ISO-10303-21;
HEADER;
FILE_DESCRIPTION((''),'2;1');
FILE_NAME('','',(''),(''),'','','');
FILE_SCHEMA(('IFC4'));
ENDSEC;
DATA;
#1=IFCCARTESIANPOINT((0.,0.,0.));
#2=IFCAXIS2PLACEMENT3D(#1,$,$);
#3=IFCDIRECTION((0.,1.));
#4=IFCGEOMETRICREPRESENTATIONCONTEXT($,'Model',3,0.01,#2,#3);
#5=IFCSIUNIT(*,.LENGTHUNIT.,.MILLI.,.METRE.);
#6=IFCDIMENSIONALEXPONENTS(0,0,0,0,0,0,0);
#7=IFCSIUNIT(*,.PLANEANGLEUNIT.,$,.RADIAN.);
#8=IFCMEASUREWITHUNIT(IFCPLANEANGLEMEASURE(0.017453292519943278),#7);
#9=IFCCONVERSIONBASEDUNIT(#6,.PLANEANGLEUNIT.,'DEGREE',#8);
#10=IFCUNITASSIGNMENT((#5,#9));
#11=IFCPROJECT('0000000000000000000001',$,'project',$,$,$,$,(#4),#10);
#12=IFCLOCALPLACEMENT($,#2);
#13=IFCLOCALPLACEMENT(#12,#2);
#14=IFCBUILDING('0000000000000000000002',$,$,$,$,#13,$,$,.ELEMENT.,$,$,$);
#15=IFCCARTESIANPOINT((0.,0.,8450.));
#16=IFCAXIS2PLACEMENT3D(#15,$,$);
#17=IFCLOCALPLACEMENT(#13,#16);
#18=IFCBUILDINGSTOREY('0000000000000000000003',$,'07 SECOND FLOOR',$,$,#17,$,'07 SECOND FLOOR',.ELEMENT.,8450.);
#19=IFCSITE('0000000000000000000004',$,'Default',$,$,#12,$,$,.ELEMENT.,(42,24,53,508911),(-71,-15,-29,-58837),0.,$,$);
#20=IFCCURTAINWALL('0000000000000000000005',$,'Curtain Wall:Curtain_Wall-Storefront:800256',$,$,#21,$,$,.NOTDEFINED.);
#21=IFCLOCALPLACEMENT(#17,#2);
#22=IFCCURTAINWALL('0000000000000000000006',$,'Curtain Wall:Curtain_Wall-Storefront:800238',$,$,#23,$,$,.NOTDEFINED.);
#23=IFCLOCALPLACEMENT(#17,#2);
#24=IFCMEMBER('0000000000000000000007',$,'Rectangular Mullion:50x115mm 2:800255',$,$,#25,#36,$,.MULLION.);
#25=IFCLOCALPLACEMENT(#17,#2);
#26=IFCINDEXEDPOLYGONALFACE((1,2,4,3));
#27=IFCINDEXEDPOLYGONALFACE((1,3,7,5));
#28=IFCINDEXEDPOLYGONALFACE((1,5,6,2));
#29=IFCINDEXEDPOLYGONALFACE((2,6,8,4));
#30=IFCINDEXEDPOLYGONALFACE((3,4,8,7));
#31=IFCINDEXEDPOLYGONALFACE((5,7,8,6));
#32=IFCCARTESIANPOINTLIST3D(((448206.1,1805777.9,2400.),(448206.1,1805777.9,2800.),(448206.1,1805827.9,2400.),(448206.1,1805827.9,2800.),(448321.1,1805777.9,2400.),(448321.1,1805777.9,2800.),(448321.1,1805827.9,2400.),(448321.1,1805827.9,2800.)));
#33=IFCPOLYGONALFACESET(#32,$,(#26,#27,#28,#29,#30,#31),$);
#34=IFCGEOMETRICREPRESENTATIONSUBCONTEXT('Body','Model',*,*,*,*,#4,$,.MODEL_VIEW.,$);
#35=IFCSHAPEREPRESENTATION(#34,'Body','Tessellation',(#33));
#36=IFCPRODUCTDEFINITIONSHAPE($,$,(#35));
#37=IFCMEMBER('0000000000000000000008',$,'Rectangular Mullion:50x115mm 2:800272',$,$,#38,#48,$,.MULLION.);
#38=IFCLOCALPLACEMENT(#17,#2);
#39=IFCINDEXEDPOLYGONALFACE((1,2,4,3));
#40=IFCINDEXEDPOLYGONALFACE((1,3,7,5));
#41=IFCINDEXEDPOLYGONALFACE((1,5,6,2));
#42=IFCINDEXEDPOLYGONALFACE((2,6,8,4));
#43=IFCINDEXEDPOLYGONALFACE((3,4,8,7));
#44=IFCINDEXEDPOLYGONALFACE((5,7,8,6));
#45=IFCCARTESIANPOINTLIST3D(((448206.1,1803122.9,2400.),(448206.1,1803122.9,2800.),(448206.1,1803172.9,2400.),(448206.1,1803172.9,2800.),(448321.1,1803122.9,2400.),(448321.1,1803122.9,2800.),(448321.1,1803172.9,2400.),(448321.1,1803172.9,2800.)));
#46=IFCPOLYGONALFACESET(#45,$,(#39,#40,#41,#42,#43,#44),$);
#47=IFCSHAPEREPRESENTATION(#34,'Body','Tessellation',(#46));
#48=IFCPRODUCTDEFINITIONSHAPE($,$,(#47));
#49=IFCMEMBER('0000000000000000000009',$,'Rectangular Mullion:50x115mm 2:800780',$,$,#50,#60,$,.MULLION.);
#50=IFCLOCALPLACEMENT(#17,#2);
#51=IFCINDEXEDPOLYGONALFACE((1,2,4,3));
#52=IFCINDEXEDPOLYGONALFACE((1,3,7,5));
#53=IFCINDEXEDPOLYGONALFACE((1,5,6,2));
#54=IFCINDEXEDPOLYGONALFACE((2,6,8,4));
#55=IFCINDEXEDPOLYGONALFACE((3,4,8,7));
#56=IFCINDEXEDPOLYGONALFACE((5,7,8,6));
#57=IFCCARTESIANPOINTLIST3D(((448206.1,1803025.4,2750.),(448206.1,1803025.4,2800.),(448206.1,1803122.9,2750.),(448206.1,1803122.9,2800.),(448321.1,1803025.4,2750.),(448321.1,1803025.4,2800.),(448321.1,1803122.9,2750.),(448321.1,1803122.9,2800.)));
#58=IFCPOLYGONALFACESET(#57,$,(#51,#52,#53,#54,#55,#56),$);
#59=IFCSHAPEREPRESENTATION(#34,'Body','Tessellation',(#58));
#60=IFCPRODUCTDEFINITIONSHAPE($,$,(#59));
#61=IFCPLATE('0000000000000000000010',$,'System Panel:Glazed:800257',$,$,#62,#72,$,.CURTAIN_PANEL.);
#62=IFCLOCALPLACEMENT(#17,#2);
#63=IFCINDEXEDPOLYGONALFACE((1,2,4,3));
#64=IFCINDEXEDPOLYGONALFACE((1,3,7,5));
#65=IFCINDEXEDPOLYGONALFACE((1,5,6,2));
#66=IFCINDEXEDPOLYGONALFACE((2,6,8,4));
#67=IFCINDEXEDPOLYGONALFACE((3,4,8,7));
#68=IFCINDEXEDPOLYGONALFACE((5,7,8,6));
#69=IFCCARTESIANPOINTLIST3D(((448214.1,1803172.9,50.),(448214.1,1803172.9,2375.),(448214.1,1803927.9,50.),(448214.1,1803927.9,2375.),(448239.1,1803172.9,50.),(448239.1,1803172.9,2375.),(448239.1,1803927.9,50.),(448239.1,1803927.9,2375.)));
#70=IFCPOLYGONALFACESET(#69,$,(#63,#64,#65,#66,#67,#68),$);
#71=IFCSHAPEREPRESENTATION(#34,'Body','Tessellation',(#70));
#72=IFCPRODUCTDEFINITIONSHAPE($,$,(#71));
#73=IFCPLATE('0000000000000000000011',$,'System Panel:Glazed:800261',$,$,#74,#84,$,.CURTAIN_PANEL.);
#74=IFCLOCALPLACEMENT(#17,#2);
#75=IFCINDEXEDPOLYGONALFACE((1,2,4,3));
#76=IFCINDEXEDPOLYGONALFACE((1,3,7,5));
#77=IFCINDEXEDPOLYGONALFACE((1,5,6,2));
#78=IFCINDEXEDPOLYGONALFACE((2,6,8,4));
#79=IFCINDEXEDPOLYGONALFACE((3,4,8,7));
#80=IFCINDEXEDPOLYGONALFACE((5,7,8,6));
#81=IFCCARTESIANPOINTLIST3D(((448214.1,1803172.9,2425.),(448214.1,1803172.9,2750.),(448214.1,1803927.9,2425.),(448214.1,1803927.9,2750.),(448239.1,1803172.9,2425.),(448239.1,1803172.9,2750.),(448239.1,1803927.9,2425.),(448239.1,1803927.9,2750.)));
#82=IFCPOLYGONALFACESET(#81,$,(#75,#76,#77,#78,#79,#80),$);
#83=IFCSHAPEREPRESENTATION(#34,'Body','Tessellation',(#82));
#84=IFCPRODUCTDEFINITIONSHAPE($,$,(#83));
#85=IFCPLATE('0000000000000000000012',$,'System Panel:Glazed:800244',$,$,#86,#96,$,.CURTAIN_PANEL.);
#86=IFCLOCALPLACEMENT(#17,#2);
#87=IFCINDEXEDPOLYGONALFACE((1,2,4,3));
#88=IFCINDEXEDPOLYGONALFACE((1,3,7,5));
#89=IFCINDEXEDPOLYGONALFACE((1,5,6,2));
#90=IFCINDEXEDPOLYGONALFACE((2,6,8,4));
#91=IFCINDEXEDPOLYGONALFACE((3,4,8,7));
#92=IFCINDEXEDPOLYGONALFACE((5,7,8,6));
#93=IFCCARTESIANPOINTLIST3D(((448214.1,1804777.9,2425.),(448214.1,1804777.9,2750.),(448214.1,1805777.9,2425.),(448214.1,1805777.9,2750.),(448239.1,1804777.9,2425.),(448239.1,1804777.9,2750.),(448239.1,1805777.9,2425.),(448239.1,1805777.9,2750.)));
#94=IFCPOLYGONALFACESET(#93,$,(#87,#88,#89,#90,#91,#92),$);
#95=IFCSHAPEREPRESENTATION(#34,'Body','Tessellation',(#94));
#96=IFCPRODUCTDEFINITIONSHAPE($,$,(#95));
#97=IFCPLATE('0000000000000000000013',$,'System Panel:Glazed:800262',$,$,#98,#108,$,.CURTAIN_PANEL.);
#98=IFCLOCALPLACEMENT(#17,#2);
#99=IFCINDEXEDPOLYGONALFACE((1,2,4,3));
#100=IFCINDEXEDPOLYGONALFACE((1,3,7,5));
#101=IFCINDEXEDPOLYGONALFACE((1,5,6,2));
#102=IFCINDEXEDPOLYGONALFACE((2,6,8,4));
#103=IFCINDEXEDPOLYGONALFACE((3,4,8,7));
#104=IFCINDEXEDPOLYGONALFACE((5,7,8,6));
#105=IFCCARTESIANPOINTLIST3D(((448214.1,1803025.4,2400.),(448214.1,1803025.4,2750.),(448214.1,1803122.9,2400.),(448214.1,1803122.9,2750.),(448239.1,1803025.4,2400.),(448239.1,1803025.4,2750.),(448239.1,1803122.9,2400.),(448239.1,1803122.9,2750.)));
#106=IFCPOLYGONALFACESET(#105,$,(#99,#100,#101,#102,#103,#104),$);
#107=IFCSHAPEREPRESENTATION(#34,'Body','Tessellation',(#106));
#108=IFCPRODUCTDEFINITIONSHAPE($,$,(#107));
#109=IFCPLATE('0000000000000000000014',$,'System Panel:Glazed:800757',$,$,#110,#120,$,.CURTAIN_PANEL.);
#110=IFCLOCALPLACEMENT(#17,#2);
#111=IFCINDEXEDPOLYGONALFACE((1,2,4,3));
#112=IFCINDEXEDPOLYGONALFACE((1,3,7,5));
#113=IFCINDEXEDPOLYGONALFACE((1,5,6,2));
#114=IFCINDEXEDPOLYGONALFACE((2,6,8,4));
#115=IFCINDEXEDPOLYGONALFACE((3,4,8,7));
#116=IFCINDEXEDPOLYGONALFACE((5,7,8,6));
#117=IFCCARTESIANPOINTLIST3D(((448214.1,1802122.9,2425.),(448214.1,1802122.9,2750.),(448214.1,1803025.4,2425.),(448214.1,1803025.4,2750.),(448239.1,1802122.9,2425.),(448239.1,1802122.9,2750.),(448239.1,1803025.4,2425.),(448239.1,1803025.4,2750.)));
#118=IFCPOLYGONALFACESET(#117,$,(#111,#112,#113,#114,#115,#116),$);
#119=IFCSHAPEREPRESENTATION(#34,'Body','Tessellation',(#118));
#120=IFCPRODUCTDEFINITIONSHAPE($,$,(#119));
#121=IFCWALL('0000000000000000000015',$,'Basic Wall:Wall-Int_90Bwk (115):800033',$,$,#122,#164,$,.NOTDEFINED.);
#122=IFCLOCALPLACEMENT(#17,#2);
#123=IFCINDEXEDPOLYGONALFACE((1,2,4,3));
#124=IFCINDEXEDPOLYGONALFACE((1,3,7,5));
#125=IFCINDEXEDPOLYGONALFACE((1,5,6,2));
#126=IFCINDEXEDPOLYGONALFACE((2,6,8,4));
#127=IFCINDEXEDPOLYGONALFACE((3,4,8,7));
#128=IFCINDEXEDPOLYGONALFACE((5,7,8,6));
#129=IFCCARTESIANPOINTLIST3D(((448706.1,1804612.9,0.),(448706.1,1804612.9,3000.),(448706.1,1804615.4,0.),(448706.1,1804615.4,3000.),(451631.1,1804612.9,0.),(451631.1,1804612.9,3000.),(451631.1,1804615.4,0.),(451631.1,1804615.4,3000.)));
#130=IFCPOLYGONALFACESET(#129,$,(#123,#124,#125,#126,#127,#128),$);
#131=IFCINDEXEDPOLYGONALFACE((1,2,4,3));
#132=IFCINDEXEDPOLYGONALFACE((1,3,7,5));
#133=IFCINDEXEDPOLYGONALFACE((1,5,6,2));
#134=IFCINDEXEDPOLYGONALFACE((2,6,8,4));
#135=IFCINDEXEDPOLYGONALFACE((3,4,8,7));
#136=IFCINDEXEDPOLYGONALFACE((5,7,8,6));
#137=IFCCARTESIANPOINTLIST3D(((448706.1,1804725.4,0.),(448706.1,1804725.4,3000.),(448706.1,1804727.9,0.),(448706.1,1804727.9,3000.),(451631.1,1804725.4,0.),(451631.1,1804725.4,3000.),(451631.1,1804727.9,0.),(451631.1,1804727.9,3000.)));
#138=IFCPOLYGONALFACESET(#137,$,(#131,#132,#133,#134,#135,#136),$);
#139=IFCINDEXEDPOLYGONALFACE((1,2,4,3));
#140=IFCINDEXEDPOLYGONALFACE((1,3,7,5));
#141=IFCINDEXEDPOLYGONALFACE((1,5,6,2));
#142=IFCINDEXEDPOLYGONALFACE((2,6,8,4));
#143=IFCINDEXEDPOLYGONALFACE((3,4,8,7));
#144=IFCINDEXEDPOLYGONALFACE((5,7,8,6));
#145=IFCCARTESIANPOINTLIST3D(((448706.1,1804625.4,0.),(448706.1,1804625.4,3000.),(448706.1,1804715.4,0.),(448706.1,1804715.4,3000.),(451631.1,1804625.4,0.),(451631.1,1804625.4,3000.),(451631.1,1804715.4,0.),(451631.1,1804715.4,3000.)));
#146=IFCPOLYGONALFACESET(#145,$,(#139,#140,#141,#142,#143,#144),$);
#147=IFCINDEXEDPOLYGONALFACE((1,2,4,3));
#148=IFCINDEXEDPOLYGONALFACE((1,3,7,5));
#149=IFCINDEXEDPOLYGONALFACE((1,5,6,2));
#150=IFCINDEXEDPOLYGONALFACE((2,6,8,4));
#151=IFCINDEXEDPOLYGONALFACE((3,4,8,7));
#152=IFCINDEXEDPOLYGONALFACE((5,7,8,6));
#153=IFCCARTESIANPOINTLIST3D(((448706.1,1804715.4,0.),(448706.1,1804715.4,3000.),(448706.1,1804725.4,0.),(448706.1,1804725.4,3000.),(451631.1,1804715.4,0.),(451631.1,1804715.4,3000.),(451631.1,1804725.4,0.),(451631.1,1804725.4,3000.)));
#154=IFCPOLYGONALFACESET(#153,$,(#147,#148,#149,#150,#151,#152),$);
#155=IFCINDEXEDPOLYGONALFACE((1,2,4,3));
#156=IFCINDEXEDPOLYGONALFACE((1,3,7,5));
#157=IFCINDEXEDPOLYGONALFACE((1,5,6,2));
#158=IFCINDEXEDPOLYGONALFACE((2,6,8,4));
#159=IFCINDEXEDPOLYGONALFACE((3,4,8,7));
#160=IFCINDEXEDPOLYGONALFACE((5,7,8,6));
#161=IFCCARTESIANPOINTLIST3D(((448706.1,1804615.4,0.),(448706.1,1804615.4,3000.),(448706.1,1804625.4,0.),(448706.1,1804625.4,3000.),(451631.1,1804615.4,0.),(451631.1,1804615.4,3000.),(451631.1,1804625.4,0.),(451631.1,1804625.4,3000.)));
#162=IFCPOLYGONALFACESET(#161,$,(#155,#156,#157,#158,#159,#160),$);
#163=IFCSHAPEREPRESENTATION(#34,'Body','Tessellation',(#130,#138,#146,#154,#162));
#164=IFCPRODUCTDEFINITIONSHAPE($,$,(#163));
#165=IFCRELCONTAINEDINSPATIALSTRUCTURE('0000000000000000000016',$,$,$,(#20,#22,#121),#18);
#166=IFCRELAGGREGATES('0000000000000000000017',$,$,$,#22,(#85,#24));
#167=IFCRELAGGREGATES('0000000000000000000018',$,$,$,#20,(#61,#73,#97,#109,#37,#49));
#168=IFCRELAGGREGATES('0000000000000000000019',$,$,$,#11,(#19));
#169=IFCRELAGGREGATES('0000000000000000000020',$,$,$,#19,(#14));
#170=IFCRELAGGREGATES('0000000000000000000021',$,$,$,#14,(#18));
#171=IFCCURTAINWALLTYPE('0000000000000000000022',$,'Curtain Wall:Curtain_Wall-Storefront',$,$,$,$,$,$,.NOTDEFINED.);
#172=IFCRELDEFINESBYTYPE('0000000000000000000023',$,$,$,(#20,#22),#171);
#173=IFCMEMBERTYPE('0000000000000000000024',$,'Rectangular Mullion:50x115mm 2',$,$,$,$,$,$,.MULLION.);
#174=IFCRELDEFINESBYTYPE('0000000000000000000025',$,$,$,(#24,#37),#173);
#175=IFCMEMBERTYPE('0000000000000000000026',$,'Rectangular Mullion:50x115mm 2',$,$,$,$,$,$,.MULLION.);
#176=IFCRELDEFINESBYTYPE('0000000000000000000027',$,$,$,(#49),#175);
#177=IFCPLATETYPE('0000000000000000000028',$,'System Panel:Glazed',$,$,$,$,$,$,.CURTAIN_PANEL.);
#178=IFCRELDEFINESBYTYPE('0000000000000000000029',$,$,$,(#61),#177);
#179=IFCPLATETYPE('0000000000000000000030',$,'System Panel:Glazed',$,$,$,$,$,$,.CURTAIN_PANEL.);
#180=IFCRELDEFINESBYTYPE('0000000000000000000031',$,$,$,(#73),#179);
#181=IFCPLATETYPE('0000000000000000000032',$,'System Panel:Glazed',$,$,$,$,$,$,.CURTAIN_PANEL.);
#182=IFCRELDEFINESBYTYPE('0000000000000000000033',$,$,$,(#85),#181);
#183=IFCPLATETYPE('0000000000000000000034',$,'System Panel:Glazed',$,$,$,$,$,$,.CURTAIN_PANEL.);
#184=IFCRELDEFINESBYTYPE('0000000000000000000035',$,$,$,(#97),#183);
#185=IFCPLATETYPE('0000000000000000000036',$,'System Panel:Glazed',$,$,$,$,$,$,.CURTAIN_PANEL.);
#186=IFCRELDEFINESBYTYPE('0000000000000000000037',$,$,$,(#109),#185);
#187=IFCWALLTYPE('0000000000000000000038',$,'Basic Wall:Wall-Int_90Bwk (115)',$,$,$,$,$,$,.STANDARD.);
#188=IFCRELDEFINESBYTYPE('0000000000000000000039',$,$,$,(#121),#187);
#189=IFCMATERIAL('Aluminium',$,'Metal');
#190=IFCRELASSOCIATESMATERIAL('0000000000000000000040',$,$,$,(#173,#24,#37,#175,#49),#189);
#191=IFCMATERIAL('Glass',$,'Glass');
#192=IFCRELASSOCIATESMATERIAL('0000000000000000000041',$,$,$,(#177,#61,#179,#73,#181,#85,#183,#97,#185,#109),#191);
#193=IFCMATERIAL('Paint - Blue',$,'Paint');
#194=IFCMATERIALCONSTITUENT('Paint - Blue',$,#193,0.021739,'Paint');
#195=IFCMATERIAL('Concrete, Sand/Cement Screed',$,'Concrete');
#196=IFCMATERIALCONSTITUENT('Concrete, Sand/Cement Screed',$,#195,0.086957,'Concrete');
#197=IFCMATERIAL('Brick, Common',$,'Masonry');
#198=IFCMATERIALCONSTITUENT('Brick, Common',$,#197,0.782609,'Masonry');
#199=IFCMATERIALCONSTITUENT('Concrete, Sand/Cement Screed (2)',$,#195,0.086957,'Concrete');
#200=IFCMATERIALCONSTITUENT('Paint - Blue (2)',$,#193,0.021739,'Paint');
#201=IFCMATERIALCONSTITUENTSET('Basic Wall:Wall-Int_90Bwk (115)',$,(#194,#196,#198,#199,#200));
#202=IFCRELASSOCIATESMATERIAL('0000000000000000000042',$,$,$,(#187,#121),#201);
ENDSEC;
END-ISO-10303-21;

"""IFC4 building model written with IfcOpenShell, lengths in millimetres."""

from ifc_helpers import new_model, entity, si_unit, converted_unit, direction, frame, origin, place, context, subcontext, project, spatial, indexed_curve, outline, extrude, source, transform, mapped, material, constituent, constituent_set, type_object, type_shapes, element, aggregate, save


model = new_model("IFC4")

# Units and contexts
model_context = context("Model", 3, precision=0.01, world=origin(), true_north=direction((0.0, 1.0)))
body_context = subcontext(model_context, "Body", "Model", "MODEL_VIEW")
ifc_project = project(units=[si_unit("LENGTHUNIT", "METRE", prefix="MILLI"), converted_unit("PLANEANGLEUNIT", "DEGREE", entity("IfcPlaneAngleMeasure", 0.017453292519943278), si_unit("PLANEANGLEUNIT", "RADIAN"), dimensions=[0, 0, 0, 0, 0, 0, 0])], contexts=[model_context])

# Site, building, storey
site_placement = place(None, origin())
site = spatial("IfcSite", under=ifc_project, at=site_placement, Name="Default", CompositionType="ELEMENT", RefLatitude=(42, 24, 53, 508911), RefLongitude=(-71, -15, -29, -58837), RefElevation=0.0)
building_placement = place(site_placement, origin())
building = spatial("IfcBuilding", under=site, at=building_placement, CompositionType="ELEMENT")
storey_placement = place(building_placement, frame((0.0, 0.0, 8450.0)))
storey = spatial("IfcBuildingStorey", under=building, at=storey_placement, Name="07 SECOND FLOOR", LongName="07 SECOND FLOOR", CompositionType="ELEMENT", Elevation=8450.0)

# Curtain wall
curtain_wall_type = type_object("IfcCurtainWallType", Name="Curtain Wall:Curtain_Wall-Storefront", PredefinedType="NOTDEFINED")
curtain_wall_1_placement = place(storey_placement, frame((0.0, 0.0, -8450.0)))
curtain_wall_1 = element("IfcCurtainWall", 1, at=curtain_wall_1_placement, inside=storey, type_object=curtain_wall_type, Name="Curtain Wall:Curtain_Wall-Storefront:800256", PredefinedType="NOTDEFINED")
ifc_material_1 = material(Name="Aluminium", Category="Metal")

# Curtain wall
curtain_wall_2_placement = place(storey_placement, frame((0.0, 0.0, -8450.0)))
curtain_wall_2 = element("IfcCurtainWall", 2, at=curtain_wall_2_placement, inside=storey, type_object=curtain_wall_type, Name="Curtain Wall:Curtain_Wall-Storefront:800238", PredefinedType="NOTDEFINED")

# Members
member_type_1 = type_object("IfcMemberType", Name="Rectangular Mullion:50x115mm 2", PredefinedType="MULLION", material=ifc_material_1)
shared_shape_1 = source(origin(), body_context, "Body", "SweptSolid", [
    extrude(outline(indexed_curve([(-25.0, -57.5), (25.0, -57.5), (25.0, 57.5), (-25.0, 57.5), (-25.0, -57.5)], self_intersect=False)), frame((0.0, 0.0, -400.0), z_axis=(0.0, 0.0, 1.0), x_axis=(-1.0, 0.0, 0.0)), (0.0, 0.0, 1.0), 400.0),
])
type_shapes(member_type_1, [shared_shape_1])
member_1_placement = place(curtain_wall_2_placement, frame((448263.6, 1805802.9, 10850.0), z_axis=(0.0, 0.0, -1.0), x_axis=(0.0, -1.0, 0.0)))
member_1 = element("IfcMember", 3, at=member_1_placement, type_object=member_type_1, material=ifc_material_1, Name="Rectangular Mullion:50x115mm 2:800255", PredefinedType="MULLION", context=body_context, shape_type="MappedRepresentation", body=[
    mapped(shared_shape_1, transform((0.0, 0.0, 0.0), scale=1.0)),
])
member_2_placement = place(curtain_wall_1_placement, frame((448263.6, 1803147.9, 10850.0), z_axis=(0.0, 0.0, -1.0), x_axis=(0.0, -1.0, 0.0)))
member_2 = element("IfcMember", 4, at=member_2_placement, type_object=member_type_1, material=ifc_material_1, Name="Rectangular Mullion:50x115mm 2:800272", PredefinedType="MULLION", context=body_context, shape_type="MappedRepresentation", body=[
    mapped(shared_shape_1, transform((0.0, 0.0, 0.0), scale=1.0)),
])
member_type_2 = type_object("IfcMemberType", Name="Rectangular Mullion:50x115mm 2", PredefinedType="MULLION", material=ifc_material_1)
shared_shape_2 = source(origin(), body_context, "Body", "SweptSolid", [
    extrude(outline(indexed_curve([(-25.0, -57.5), (25.0, -57.5), (25.0, 57.5), (-25.0, 57.5), (-25.0, -57.5)], self_intersect=False)), frame((-25.0, 0.0, -97.5), z_axis=(0.0, 0.0, 1.0), x_axis=(-1.0, 0.0, 0.0)), (0.0, 0.0, 1.0), 97.5),
])
type_shapes(member_type_2, [shared_shape_2])
member_3_placement = place(curtain_wall_1_placement, frame((448263.6, 1803025.4, 11250.0), z_axis=(0.0, -1.0, 0.0), x_axis=(0.0, 0.0, 1.0)))
member_3 = element("IfcMember", 5, at=member_3_placement, type_object=member_type_2, material=ifc_material_1, Name="Rectangular Mullion:50x115mm 2:800780", PredefinedType="MULLION", context=body_context, shape_type="MappedRepresentation", body=[
    mapped(shared_shape_2, transform((0.0, 0.0, 0.0), scale=1.0)),
])

# Plates
ifc_material_2 = material(Name="Glass", Category="Glass")
plate_type_1 = type_object("IfcPlateType", Name="System Panel:Glazed", PredefinedType="CURTAIN_PANEL", material=ifc_material_2)
shared_shape_3 = source(origin(), body_context, "Body", "SweptSolid", [
    extrude(outline(indexed_curve([(-12.5, -377.5), (12.5, -377.5), (12.5, 377.5), (-12.5, 377.5), (-12.5, -377.5)], self_intersect=False)), frame((0.0, -37.0, 0.0), z_axis=(0.0, 0.0, 1.0), x_axis=(0.0, 1.0, 0.0)), (0.0, 0.0, 1.0), 2325.0),
])
type_shapes(plate_type_1, [shared_shape_3])
plate_1_placement = place(curtain_wall_1_placement, frame((448263.6, 1803550.4, 8500.0), z_axis=(0.0, 0.0, 1.0), x_axis=(0.0, -1.0, 0.0)))
plate_1 = element("IfcPlate", 6, at=plate_1_placement, type_object=plate_type_1, material=ifc_material_2, Name="System Panel:Glazed:800257", PredefinedType="CURTAIN_PANEL", context=body_context, shape_type="MappedRepresentation", body=[
    mapped(shared_shape_3, transform((0.0, 0.0, 0.0), scale=1.0)),
])
plate_type_2 = type_object("IfcPlateType", Name="System Panel:Glazed", PredefinedType="CURTAIN_PANEL", material=ifc_material_2)
shared_shape_4 = source(origin(), body_context, "Body", "SweptSolid", [
    extrude(outline(indexed_curve([(-12.5, -377.5), (12.5, -377.5), (12.5, 377.5), (-12.5, 377.5), (-12.5, -377.5)], self_intersect=False)), frame((0.0, -37.0, 0.0), z_axis=(0.0, 0.0, 1.0), x_axis=(0.0, 1.0, 0.0)), (0.0, 0.0, 1.0), 325.0),
])
type_shapes(plate_type_2, [shared_shape_4])
plate_2_placement = place(curtain_wall_1_placement, frame((448263.6, 1803550.4, 10875.0), z_axis=(0.0, 0.0, 1.0), x_axis=(0.0, -1.0, 0.0)))
plate_2 = element("IfcPlate", 7, at=plate_2_placement, type_object=plate_type_2, material=ifc_material_2, Name="System Panel:Glazed:800261", PredefinedType="CURTAIN_PANEL", context=body_context, shape_type="MappedRepresentation", body=[
    mapped(shared_shape_4, transform((0.0, 0.0, 0.0), scale=1.0)),
])
plate_type_3 = type_object("IfcPlateType", Name="System Panel:Glazed", PredefinedType="CURTAIN_PANEL", material=ifc_material_2)
shared_shape_5 = source(origin(), body_context, "Body", "SweptSolid", [
    extrude(outline(indexed_curve([(-12.5, -500.0), (12.5, -500.0), (12.5, 500.0), (-12.5, 500.0), (-12.5, -500.0)], self_intersect=False)), frame((0.0, -37.0, 0.0), z_axis=(0.0, 0.0, 1.0), x_axis=(0.0, 1.0, 0.0)), (0.0, 0.0, 1.0), 325.0),
])
type_shapes(plate_type_3, [shared_shape_5])
plate_3_placement = place(curtain_wall_2_placement, frame((448263.6, 1805277.9, 10875.0), z_axis=(0.0, 0.0, 1.0), x_axis=(0.0, -1.0, 0.0)))
plate_3 = element("IfcPlate", 8, at=plate_3_placement, type_object=plate_type_3, material=ifc_material_2, Name="System Panel:Glazed:800244", PredefinedType="CURTAIN_PANEL", context=body_context, shape_type="MappedRepresentation", body=[
    mapped(shared_shape_5, transform((0.0, 0.0, 0.0), scale=1.0)),
])
plate_type_4 = type_object("IfcPlateType", Name="System Panel:Glazed", PredefinedType="CURTAIN_PANEL", material=ifc_material_2)
shared_shape_6 = source(origin(), body_context, "Body", "SweptSolid", [
    extrude(outline(indexed_curve([(-12.5, -48.8), (12.5, -48.8), (12.5, 48.8), (-12.5, 48.8), (-12.5, -48.8)], self_intersect=False)), frame((0.0, -37.0, 0.0), z_axis=(0.0, 0.0, 1.0), x_axis=(0.0, 1.0, 0.0)), (0.0, 0.0, 1.0), 350.0),
])
type_shapes(plate_type_4, [shared_shape_6])
plate_4_placement = place(curtain_wall_1_placement, frame((448263.6, 1803074.2, 10850.0), z_axis=(0.0, 0.0, 1.0), x_axis=(0.0, -1.0, 0.0)))
plate_4 = element("IfcPlate", 9, at=plate_4_placement, type_object=plate_type_4, material=ifc_material_2, Name="System Panel:Glazed:800262", PredefinedType="CURTAIN_PANEL", context=body_context, shape_type="MappedRepresentation", body=[
    mapped(shared_shape_6, transform((0.0, 0.0, 0.0), scale=1.0)),
])
plate_type_5 = type_object("IfcPlateType", Name="System Panel:Glazed", PredefinedType="CURTAIN_PANEL", material=ifc_material_2)
shared_shape_7 = source(origin(), body_context, "Body", "SweptSolid", [
    extrude(outline(indexed_curve([(-12.5, -451.3), (12.5, -451.3), (12.5, 451.3), (-12.5, 451.3), (-12.5, -451.3)], self_intersect=False)), frame((0.0, -37.0, 0.0), z_axis=(0.0, 0.0, 1.0), x_axis=(0.0, 1.0, 0.0)), (0.0, 0.0, 1.0), 325.0),
])
type_shapes(plate_type_5, [shared_shape_7])
plate_5_placement = place(curtain_wall_1_placement, frame((448263.6, 1802574.2, 10875.0), z_axis=(0.0, 0.0, 1.0), x_axis=(0.0, -1.0, 0.0)))
plate_5 = element("IfcPlate", 10, at=plate_5_placement, type_object=plate_type_5, material=ifc_material_2, Name="System Panel:Glazed:800757", PredefinedType="CURTAIN_PANEL", context=body_context, shape_type="MappedRepresentation", body=[
    mapped(shared_shape_7, transform((0.0, 0.0, 0.0), scale=1.0)),
])

# Wall
ifc_material_3 = material(Name="Paint - Blue", Category="Paint")
ifc_constituent_1 = constituent(ifc_material_3, Name="Paint - Blue", Category="Paint", fraction=0.021739)
ifc_material_4 = material(Name="Concrete, Sand/Cement Screed", Category="Concrete")
ifc_constituent_2 = constituent(ifc_material_4, Name="Concrete, Sand/Cement Screed", Category="Concrete", fraction=0.086957)
ifc_material_5 = material(Name="Brick, Common", Category="Masonry")
ifc_constituent_3 = constituent(ifc_material_5, Name="Brick, Common", Category="Masonry", fraction=0.782609)
ifc_constituent_4 = constituent(ifc_material_4, Name="Concrete, Sand/Cement Screed (2)", Category="Concrete", fraction=0.086957)
ifc_constituent_5 = constituent(ifc_material_3, Name="Paint - Blue (2)", Category="Paint", fraction=0.021739)
ifc_constituent_set_1 = constituent_set(constituents=[ifc_constituent_1, ifc_constituent_2, ifc_constituent_3, ifc_constituent_4, ifc_constituent_5], Name="Basic Wall:Wall-Int_90Bwk (115)")
wall_type_1 = type_object("IfcWallType", Name="Basic Wall:Wall-Int_90Bwk (115)", PredefinedType="STANDARD", material=ifc_constituent_set_1)
wall_1_placement = place(storey_placement, frame((448706.1, 1804670.4, 0.0)))
element("IfcWall", 11, at=wall_1_placement, inside=storey, type_object=wall_type_1, material=ifc_constituent_set_1, Name="Basic Wall:Wall-Int_90Bwk (115):800033", PredefinedType="NOTDEFINED", context=body_context, shape_type="SweptSolid", body=[
    extrude(outline(indexed_curve([(-1.2, -1462.5), (1.3, -1462.5), (1.3, 1462.5), (-1.2, 1462.5), (-1.2, -1462.5)], self_intersect=False)), frame((1462.5, -56.3, 0.0), z_axis=(0.0, 0.0, 1.0), x_axis=(0.0, 1.0, 0.0)), (0.0, 0.0, 1.0), 3000.0),
    extrude(outline(indexed_curve([(-1.3, -1462.5), (1.3, -1462.5), (1.3, 1462.5), (-1.3, 1462.5), (-1.3, -1462.5)], self_intersect=False)), frame((1462.5, 56.3, 0.0), z_axis=(0.0, 0.0, 1.0), x_axis=(0.0, -1.0, 0.0)), (0.0, 0.0, 1.0), 3000.0),
    extrude(outline(indexed_curve([(-1462.5, -45.0), (1462.5, -45.0), (1462.5, 45.0), (-1462.5, 45.0), (-1462.5, -45.0)], self_intersect=False)), frame((1462.5, 0.0, 0.0)), (0.0, 0.0, 1.0), 3000.0),
    extrude(outline(indexed_curve([(-1462.5, -5.0), (1462.5, -5.0), (1462.5, 5.0), (-1462.5, 5.0), (-1462.5, -5.0)], self_intersect=False)), frame((1462.5, 50.0, 0.0)), (0.0, 0.0, 1.0), 3000.0),
    extrude(outline(indexed_curve([(-1462.5, -5.0), (1462.5, -5.0), (1462.5, 5.0), (-1462.5, 5.0), (-1462.5, -5.0)], self_intersect=False)), frame((1462.5, -50.0, 0.0)), (0.0, 0.0, 1.0), 3000.0),
])

aggregate(curtain_wall_2, [plate_3, member_1])
aggregate(curtain_wall_1, [plate_1, plate_2, plate_4, plate_5, member_2, member_3])

save(model, "model.ifc")
